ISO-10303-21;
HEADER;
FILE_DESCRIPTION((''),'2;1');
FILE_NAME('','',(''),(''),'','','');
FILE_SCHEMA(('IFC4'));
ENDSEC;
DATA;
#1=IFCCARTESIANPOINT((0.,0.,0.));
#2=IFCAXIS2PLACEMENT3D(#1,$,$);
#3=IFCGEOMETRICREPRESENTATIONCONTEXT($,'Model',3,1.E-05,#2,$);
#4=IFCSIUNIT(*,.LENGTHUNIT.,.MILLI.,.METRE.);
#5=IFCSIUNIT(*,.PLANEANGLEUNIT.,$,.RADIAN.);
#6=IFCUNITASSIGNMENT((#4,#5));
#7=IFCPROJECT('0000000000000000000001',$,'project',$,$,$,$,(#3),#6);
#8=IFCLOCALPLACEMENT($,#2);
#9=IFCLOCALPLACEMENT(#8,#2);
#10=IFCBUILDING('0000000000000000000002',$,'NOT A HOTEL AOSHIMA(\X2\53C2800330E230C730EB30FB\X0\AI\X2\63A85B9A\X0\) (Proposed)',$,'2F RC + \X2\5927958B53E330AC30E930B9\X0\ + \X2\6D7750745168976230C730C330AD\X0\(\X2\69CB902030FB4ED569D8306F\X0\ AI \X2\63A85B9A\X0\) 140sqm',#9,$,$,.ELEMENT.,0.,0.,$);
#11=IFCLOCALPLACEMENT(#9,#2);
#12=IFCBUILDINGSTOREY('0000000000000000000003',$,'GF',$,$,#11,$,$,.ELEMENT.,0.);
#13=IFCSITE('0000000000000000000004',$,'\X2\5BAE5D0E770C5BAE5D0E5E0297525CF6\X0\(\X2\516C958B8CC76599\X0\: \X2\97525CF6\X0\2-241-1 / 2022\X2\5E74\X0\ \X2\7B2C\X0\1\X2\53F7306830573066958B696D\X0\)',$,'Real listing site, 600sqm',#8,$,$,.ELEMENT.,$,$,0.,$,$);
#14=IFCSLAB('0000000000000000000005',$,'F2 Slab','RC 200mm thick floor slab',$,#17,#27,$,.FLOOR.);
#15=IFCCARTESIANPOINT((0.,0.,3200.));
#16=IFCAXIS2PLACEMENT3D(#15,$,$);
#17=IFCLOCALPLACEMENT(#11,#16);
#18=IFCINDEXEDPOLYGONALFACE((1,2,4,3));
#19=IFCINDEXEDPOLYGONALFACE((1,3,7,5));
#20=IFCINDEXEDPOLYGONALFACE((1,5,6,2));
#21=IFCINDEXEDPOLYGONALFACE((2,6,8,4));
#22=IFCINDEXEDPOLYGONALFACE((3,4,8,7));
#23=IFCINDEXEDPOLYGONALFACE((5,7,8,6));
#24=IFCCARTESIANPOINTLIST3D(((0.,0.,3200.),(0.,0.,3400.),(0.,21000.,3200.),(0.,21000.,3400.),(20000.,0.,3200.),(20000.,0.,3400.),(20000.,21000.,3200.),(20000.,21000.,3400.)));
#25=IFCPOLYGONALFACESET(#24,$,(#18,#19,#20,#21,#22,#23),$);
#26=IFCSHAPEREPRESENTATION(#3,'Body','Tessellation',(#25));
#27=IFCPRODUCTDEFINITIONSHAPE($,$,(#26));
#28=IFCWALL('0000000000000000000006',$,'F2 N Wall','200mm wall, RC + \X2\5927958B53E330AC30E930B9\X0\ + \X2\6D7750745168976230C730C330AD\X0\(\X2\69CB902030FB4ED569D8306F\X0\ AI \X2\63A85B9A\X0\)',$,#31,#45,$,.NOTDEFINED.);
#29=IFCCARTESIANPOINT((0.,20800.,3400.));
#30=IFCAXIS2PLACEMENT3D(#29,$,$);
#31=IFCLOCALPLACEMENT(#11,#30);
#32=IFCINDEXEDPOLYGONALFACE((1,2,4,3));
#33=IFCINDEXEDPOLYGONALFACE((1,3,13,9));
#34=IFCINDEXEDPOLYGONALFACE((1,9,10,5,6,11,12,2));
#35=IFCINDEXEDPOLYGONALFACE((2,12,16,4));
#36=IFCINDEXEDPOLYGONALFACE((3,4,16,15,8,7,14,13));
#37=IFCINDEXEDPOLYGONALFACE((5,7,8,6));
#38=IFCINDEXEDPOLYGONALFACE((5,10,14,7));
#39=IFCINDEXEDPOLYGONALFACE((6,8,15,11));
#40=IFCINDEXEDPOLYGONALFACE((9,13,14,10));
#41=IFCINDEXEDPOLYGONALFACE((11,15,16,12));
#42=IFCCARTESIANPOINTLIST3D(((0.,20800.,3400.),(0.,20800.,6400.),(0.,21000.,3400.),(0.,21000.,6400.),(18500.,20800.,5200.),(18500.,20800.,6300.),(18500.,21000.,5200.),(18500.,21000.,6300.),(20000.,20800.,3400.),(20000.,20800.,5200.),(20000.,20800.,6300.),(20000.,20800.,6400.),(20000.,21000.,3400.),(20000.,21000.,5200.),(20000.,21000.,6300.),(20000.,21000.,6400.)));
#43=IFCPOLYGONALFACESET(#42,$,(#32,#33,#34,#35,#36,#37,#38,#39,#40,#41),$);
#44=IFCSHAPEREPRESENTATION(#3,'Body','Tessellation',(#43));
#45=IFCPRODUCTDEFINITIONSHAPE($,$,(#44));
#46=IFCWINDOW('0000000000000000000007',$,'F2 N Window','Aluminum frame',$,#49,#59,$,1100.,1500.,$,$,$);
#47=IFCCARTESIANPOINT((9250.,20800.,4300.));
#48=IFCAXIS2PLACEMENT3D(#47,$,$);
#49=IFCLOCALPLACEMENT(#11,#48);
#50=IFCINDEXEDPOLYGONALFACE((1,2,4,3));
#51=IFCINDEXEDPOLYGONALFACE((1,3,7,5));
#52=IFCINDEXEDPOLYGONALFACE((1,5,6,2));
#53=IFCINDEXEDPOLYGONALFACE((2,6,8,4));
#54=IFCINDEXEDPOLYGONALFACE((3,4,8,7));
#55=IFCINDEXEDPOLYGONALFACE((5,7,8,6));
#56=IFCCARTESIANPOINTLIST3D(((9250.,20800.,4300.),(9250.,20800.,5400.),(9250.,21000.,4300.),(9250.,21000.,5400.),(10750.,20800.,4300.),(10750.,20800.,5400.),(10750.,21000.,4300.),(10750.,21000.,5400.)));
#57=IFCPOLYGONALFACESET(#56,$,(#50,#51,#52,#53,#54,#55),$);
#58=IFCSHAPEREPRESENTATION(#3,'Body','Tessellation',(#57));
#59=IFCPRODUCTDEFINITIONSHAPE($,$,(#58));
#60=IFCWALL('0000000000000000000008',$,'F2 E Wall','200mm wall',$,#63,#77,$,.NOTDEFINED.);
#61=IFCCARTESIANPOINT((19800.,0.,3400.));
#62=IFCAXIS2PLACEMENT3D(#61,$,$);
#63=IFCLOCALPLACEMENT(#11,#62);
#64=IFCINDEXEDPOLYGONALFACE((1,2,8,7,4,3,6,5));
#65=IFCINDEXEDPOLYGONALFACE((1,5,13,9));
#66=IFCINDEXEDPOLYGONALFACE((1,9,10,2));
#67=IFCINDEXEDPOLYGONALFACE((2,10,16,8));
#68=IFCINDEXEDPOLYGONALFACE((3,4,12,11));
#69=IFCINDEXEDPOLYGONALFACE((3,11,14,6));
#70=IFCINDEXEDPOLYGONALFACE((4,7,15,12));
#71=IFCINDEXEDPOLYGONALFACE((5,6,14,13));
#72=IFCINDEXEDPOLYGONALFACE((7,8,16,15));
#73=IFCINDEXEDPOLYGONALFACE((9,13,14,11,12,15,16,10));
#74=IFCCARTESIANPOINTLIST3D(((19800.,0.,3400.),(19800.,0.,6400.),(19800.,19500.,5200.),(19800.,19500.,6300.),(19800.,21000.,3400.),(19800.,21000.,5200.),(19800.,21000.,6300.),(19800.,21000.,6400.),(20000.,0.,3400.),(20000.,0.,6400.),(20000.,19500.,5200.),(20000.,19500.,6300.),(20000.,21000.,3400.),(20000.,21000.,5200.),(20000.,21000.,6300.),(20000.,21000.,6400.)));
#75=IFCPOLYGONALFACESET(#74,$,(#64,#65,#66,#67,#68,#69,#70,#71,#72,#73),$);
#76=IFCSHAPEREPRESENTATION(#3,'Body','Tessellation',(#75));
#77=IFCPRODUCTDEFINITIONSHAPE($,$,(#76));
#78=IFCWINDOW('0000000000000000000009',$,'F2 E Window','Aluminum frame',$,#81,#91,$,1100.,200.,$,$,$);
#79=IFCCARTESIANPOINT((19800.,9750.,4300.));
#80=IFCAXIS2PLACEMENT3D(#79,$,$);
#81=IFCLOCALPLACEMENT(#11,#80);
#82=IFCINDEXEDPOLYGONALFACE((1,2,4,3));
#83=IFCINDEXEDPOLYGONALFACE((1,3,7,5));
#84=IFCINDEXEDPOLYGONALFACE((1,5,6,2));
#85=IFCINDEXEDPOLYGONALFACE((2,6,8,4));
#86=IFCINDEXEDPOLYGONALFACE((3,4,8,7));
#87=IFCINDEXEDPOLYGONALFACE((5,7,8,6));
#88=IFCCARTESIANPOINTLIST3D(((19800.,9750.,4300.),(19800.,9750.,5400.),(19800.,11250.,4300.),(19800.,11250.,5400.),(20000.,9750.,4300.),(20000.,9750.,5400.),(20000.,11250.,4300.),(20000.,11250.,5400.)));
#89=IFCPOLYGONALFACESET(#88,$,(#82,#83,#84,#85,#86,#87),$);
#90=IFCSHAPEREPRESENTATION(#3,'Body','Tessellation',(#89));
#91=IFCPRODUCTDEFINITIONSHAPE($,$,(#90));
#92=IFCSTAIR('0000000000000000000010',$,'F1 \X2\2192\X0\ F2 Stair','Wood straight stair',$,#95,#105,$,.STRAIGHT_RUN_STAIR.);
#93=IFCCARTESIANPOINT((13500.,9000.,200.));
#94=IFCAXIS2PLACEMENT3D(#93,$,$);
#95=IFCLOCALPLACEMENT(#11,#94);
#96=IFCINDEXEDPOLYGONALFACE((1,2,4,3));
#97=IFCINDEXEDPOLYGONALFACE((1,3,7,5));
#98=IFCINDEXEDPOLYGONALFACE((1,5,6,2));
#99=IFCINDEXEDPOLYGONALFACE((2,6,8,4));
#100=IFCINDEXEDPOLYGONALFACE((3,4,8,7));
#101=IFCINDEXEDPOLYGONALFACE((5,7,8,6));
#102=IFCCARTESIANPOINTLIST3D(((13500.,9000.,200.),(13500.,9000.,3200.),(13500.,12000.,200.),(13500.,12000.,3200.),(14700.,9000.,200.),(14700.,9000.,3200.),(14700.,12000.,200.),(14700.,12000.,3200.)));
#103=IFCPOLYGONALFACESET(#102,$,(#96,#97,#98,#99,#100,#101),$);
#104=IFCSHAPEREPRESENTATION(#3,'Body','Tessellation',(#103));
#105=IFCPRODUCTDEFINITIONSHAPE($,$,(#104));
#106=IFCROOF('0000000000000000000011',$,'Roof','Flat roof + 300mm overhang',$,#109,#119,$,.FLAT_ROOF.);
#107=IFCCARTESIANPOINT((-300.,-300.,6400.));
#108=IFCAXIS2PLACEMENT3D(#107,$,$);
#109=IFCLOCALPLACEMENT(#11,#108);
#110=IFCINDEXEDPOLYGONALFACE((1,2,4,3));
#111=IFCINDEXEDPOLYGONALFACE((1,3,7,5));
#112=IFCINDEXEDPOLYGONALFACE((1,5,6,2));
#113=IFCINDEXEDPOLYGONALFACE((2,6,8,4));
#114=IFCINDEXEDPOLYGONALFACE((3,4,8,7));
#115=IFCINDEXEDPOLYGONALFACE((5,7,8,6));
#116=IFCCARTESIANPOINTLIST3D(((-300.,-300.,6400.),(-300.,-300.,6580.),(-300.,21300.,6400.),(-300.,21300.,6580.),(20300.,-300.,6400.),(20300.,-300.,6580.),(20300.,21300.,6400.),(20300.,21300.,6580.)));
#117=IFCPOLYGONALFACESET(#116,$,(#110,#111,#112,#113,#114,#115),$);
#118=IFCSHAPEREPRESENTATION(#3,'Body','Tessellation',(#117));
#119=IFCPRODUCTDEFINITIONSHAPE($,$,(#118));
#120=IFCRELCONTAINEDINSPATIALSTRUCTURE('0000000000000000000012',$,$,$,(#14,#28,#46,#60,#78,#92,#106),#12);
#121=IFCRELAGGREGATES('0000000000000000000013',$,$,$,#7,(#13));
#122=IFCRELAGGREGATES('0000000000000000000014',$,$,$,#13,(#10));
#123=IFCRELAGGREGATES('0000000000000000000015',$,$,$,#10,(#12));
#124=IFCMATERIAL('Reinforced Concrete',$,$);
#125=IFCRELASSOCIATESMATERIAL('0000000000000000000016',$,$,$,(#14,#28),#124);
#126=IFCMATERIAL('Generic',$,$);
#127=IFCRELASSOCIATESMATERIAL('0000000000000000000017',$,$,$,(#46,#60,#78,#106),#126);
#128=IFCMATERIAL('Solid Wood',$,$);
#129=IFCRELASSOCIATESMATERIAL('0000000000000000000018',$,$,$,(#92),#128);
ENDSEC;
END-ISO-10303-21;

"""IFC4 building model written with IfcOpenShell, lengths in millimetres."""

from ifc_helpers import new_model, si_unit, frame, frame_2d, origin, place, context, project, spatial, rectangle, extrude, material, element, fill, save


model = new_model("IFC4")

# Units and contexts
model_context = context("Model", 3, precision=1e-05, world=origin())
ifc_project = project(units=[si_unit("LENGTHUNIT", "METRE", prefix="MILLI"), si_unit("PLANEANGLEUNIT", "RADIAN")], contexts=[model_context])

# Site, building, storey
site_placement = place(None, origin())
site = spatial("IfcSite", under=ifc_project, at=site_placement, Name="宮崎県宮崎市青島(公開資料: 青島2-241-1 / 2022年 第1号として開業)", ObjectType="Real listing site, 600sqm", CompositionType="ELEMENT", RefElevation=0.0)
building_placement = place(site_placement, origin())
building = spatial("IfcBuilding", under=site, at=building_placement, Name="NOT A HOTEL AOSHIMA(参考モデル・AI推定) (Proposed)", ObjectType="2F RC + 大開口ガラス + 海側全面デッキ(構造・仕様は AI 推定) 140sqm", CompositionType="ELEMENT", ElevationOfRefHeight=0.0, ElevationOfTerrain=0.0)
storey_placement = place(building_placement, origin())
storey = spatial("IfcBuildingStorey", under=building, at=storey_placement, Name="GF", CompositionType="ELEMENT", Elevation=0.0)

# Slab
ifc_material_1 = material(Name="Reinforced Concrete")
slab_1_placement = place(storey_placement, frame((0.0, 0.0, 3200.0)))
element("IfcSlab", 1, at=slab_1_placement, inside=storey, material=ifc_material_1, Name="F2 Slab", Description="RC 200mm thick floor slab", PredefinedType="FLOOR", context=model_context, shape_type="SweptSolid", body=[
    extrude(rectangle(XDim=20000.0, YDim=21000.0, at=frame_2d((10000.0, 10500.0))), frame((0.0, 0.0, 3200.0)), (0.0, 0.0, 1.0), 200.0),
])

# Shared definitions
ifc_material_2 = material(Name="Generic")

# Shared definitions
ifc_material_3 = material(Name="Solid Wood")

# Walls, openings, windows
wall_1_placement = place(storey_placement, frame((0.0, 20800.0, 3400.0)))
wall_1 = element("IfcWall", 2, at=wall_1_placement, inside=storey, material=ifc_material_1, Name="F2 N Wall", Description="200mm wall, RC + 大開口ガラス + 海側全面デッキ(構造・仕様は AI 推定)", PredefinedType="NOTDEFINED", context=model_context, shape_type="SweptSolid", body=[
    extrude(rectangle(XDim=20000.0, YDim=200.0, at=frame_2d((10000.0, 100.0))), frame((0.0, 20800.0, 3400.0)), (0.0, 0.0, 1.0), 3000.0),
])
opening_1_placement = place(storey_placement, frame((9250.0, 20800.0, 4300.0)))
opening_1 = element("IfcOpeningElement", 3, at=opening_1_placement, cuts=wall_1, PredefinedType="NOTDEFINED", context=model_context, shape_type="SweptSolid", body=[
    extrude(rectangle(XDim=1500.0, YDim=200.0, at=frame_2d((750.0, 100.0))), frame((9250.0, 20800.0, 4300.0)), (0.0, 0.0, 1.0), 1100.0),
])
window_1_placement = place(storey_placement, frame((9250.0, 20800.0, 4300.0)))
window_1 = element("IfcWindow", 4, at=window_1_placement, inside=storey, material=ifc_material_2, Name="F2 N Window", Description="Aluminum frame", OverallHeight=1100.0, OverallWidth=1500.0, context=model_context, shape_type="SweptSolid", body=[
    extrude(rectangle(XDim=1500.0, YDim=200.0, at=frame_2d((750.0, 100.0))), frame((9250.0, 20800.0, 4300.0)), (0.0, 0.0, 1.0), 1100.0),
])
fill(opening_1, window_1)
wall_2_placement = place(storey_placement, frame((19800.0, 0.0, 3400.0)))
wall_2 = element("IfcWall", 5, at=wall_2_placement, inside=storey, material=ifc_material_2, Name="F2 E Wall", Description="200mm wall", PredefinedType="NOTDEFINED", context=model_context, shape_type="SweptSolid", body=[
    extrude(rectangle(XDim=200.0, YDim=21000.0, at=frame_2d((100.0, 10500.0))), frame((19800.0, 0.0, 3400.0)), (0.0, 0.0, 1.0), 3000.0),
])
opening_2_placement = place(storey_placement, frame((19800.0, 9750.0, 4300.0)))
opening_2 = element("IfcOpeningElement", 6, at=opening_2_placement, cuts=wall_2, PredefinedType="NOTDEFINED", context=model_context, shape_type="SweptSolid", body=[
    extrude(rectangle(XDim=200.0, YDim=1500.0, at=frame_2d((100.0, 750.0))), frame((19800.0, 9750.0, 4300.0)), (0.0, 0.0, 1.0), 1100.0),
])
window_2_placement = place(storey_placement, frame((19800.0, 9750.0, 4300.0)))
window_2 = element("IfcWindow", 7, at=window_2_placement, inside=storey, material=ifc_material_2, Name="F2 E Window", Description="Aluminum frame", OverallHeight=1100.0, OverallWidth=200.0, context=model_context, shape_type="SweptSolid", body=[
    extrude(rectangle(XDim=200.0, YDim=1500.0, at=frame_2d((100.0, 750.0))), frame((19800.0, 9750.0, 4300.0)), (0.0, 0.0, 1.0), 1100.0),
])
fill(opening_2, window_2)

# Stair
stair_placement = place(storey_placement, frame((13500.0, 9000.0, 200.0)))
element("IfcStair", 8, at=stair_placement, inside=storey, material=ifc_material_3, Name="F1 → F2 Stair", Description="Wood straight stair", PredefinedType="STRAIGHT_RUN_STAIR", context=model_context, shape_type="SweptSolid", body=[
    extrude(rectangle(XDim=1200.0, YDim=3000.0, at=frame_2d((600.0, 1500.0))), frame((13500.0, 9000.0, 200.0)), (0.0, 0.0, 1.0), 3000.0),
])

# Roof
roof_placement = place(storey_placement, frame((-300.0, -300.0, 6400.0)))
element("IfcRoof", 9, at=roof_placement, inside=storey, material=ifc_material_2, Name="Roof", Description="Flat roof + 300mm overhang", PredefinedType="FLAT_ROOF", context=model_context, shape_type="SweptSolid", body=[
    extrude(rectangle(XDim=20600.0, YDim=21600.0, at=frame_2d((10300.0, 10800.0))), frame((-300.0, -300.0, 6400.0)), (0.0, 0.0, 1.0), 180.0),
])

save(model, "model.ifc")
